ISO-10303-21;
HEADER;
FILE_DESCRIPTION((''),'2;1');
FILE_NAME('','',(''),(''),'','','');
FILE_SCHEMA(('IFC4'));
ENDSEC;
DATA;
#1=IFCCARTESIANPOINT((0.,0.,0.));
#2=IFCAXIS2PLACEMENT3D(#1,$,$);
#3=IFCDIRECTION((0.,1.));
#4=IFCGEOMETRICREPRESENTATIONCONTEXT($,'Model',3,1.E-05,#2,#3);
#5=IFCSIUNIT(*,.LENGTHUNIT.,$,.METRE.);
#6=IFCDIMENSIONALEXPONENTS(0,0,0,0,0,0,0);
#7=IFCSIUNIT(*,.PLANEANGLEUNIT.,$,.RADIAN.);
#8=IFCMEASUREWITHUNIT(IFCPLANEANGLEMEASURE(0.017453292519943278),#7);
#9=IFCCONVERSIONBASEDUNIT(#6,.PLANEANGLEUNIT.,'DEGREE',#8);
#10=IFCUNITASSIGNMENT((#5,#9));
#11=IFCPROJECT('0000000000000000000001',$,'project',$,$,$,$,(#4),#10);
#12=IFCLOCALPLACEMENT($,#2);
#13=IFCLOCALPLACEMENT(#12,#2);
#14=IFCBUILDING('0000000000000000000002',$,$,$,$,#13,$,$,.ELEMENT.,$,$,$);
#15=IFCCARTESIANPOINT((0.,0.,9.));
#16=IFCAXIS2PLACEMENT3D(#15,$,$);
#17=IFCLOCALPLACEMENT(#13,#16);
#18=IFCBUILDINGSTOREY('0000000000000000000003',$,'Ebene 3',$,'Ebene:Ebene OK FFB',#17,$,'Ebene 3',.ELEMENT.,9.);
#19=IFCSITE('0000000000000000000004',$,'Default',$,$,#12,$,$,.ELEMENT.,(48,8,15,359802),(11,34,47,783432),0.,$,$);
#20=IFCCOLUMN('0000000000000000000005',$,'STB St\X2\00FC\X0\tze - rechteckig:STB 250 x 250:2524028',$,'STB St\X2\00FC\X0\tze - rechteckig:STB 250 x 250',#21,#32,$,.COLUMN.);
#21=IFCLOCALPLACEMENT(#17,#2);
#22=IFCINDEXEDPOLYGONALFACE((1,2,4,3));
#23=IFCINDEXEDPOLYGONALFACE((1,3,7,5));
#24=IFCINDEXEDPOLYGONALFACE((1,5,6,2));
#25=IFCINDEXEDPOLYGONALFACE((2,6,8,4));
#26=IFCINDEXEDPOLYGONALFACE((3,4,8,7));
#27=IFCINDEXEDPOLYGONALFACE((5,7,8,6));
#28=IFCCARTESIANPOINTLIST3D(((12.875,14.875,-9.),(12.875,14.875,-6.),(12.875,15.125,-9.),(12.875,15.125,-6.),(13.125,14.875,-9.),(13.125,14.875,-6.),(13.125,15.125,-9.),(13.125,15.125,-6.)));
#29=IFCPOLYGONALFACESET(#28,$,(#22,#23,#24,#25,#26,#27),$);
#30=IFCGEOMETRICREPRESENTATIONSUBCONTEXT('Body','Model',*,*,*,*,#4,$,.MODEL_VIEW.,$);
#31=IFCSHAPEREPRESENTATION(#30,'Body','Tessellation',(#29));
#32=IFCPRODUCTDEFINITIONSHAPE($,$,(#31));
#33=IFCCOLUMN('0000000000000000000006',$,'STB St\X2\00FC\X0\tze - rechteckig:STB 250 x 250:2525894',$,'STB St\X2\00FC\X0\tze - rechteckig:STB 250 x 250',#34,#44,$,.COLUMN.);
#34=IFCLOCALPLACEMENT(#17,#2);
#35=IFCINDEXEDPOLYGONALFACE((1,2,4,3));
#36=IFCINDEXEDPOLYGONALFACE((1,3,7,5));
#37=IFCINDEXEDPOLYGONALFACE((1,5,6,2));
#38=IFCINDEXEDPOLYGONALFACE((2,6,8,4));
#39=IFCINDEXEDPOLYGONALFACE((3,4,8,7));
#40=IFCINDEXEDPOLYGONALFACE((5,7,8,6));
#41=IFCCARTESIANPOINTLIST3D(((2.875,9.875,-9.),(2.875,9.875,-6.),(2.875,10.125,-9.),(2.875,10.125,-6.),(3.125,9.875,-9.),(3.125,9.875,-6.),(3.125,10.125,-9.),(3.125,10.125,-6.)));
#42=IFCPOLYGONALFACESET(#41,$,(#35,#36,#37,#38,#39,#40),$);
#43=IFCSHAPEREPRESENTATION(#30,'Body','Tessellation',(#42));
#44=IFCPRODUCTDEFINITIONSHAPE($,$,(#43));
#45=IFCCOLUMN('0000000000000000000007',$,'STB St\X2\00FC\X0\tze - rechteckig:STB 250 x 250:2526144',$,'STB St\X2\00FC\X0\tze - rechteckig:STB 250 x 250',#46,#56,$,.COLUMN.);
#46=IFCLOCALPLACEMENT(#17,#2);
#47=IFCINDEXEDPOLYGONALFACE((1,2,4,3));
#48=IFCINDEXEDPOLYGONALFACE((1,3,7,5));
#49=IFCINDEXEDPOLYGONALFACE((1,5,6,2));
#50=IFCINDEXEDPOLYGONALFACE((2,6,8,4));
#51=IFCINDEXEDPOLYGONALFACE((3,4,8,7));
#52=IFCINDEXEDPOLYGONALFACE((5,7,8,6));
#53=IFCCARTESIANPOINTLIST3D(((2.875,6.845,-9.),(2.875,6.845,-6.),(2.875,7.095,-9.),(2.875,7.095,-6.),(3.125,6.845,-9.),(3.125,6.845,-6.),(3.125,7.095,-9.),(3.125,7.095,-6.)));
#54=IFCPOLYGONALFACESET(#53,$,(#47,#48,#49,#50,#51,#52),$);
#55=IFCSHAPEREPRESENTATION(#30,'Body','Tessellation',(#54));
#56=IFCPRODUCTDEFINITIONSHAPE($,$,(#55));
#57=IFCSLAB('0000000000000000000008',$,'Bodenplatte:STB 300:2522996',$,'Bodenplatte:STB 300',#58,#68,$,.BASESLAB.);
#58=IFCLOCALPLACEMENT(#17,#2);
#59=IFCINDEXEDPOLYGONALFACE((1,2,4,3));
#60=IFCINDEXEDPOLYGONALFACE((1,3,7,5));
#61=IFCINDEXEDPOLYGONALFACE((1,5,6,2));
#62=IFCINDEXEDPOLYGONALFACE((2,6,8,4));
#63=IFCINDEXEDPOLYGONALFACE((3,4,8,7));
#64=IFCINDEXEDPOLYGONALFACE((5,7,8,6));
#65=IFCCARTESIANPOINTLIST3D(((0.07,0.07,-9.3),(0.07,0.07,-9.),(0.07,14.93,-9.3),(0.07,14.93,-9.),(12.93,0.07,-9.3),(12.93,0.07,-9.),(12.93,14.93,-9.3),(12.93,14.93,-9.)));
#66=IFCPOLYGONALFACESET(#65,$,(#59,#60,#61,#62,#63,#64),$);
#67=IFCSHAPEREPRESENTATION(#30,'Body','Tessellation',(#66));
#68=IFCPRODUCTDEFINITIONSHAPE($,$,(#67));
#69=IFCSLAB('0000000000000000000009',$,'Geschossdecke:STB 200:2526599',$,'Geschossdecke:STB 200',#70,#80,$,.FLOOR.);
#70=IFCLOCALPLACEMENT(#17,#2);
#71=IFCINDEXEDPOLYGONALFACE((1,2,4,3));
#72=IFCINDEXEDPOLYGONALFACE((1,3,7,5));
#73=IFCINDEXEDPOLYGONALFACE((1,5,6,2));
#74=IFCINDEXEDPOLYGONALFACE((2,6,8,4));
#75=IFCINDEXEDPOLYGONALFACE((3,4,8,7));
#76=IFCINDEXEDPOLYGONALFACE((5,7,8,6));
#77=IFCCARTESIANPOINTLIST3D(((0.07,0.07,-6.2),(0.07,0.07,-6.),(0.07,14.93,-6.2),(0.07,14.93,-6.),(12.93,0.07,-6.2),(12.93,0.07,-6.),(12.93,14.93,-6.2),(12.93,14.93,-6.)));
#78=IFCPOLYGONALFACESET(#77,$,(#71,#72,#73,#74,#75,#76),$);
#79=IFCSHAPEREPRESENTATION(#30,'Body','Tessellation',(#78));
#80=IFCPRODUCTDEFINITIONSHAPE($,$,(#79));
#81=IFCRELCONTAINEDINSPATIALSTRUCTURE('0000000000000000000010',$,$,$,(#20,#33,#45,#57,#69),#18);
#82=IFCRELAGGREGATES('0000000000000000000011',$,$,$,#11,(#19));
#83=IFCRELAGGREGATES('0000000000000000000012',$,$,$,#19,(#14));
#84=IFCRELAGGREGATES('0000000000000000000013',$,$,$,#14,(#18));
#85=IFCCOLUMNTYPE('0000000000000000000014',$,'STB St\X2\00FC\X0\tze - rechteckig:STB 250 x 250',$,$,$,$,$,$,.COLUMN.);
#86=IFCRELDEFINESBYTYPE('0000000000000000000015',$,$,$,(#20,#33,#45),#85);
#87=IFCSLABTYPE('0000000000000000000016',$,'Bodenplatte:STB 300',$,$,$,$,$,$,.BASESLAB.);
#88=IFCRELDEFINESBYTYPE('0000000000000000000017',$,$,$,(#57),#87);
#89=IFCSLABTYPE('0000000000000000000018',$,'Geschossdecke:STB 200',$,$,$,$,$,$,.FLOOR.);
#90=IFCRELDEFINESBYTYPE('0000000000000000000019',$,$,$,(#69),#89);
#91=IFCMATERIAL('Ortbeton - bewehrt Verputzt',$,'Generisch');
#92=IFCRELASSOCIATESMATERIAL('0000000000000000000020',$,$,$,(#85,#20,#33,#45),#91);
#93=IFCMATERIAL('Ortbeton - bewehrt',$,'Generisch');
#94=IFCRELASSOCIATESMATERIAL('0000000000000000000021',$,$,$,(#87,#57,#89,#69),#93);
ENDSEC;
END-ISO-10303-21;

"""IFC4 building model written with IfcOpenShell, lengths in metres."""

from ifc_helpers import new_model, entity, si_unit, converted_unit, direction, frame, origin, place, context, subcontext, project, spatial, indexed_curve, outline, extrude, source, transform, mapped, material, type_object, type_shapes, element, save


model = new_model("IFC4")

# Units and contexts
model_context = context("Model", 3, precision=1e-05, world=origin(), true_north=direction((0.0, 1.0)))
body_context = subcontext(model_context, "Body", "Model", "MODEL_VIEW")
ifc_project = project(units=[si_unit("LENGTHUNIT", "METRE"), converted_unit("PLANEANGLEUNIT", "DEGREE", entity("IfcPlaneAngleMeasure", 0.017453292519943278), si_unit("PLANEANGLEUNIT", "RADIAN"), dimensions=[0, 0, 0, 0, 0, 0, 0])], contexts=[model_context])

# Site, building, storey
site_placement = place(None, origin())
site = spatial("IfcSite", under=ifc_project, at=site_placement, Name="Default", CompositionType="ELEMENT", RefLatitude=(48, 8, 15, 359802), RefLongitude=(11, 34, 47, 783432), RefElevation=0.0)
building_placement = place(site_placement, origin())
building = spatial("IfcBuilding", under=site, at=building_placement, CompositionType="ELEMENT")
storey_placement = place(building_placement, frame((0.0, 0.0, 9.0)))
storey = spatial("IfcBuildingStorey", under=building, at=storey_placement, Name="Ebene 3", ObjectType="Ebene:Ebene OK FFB", LongName="Ebene 3", CompositionType="ELEMENT", Elevation=9.0)

# Columns
ifc_material_1 = material(Name="Ortbeton - bewehrt Verputzt", Category="Generisch")
column_type = type_object("IfcColumnType", Name="STB Stütze - rechteckig:STB 250 x 250", PredefinedType="COLUMN", material=ifc_material_1)
shared_shape = source(origin(), body_context, "Body", "SweptSolid", [
    extrude(outline(indexed_curve([(-0.125, -0.125), (0.125, -0.125), (0.125, 0.125), (-0.125, 0.125), (-0.125, -0.125)], self_intersect=False)), frame((0.0, 0.0, 0.0), z_axis=(0.0, 0.0, 1.0), x_axis=(-1.0, 0.0, 0.0)), (0.0, 0.0, 1.0), 3.0),
])
type_shapes(column_type, [shared_shape])
for number, where, name in (
    (1, (13.0, 15.0, -9.0), "STB Stütze - rechteckig:STB 250 x 250:2524028"),
    (2, (3.0, 10.0, -9.0), "STB Stütze - rechteckig:STB 250 x 250:2525894"),
    (3, (3.0, 6.97, -9.0), "STB Stütze - rechteckig:STB 250 x 250:2526144"),
):
    element("IfcColumn", number, at=place(storey_placement, frame(where)), inside=storey, type_object=column_type, material=ifc_material_1, Name=name, ObjectType="STB Stütze - rechteckig:STB 250 x 250", PredefinedType="COLUMN", context=body_context, shape_type="MappedRepresentation", body=[
        mapped(shared_shape, transform((0.0, 0.0, 0.0), scale=1.0)),
    ])

# Slabs
ifc_material_2 = material(Name="Ortbeton - bewehrt", Category="Generisch")
slab_type_1 = type_object("IfcSlabType", Name="Bodenplatte:STB 300", PredefinedType="BASESLAB", material=ifc_material_2)
slab_1_placement = place(storey_placement, origin())
element("IfcSlab", 4, at=slab_1_placement, inside=storey, type_object=slab_type_1, material=ifc_material_2, Name="Bodenplatte:STB 300:2522996", ObjectType="Bodenplatte:STB 300", PredefinedType="BASESLAB", context=body_context, shape_type="SweptSolid", body=[
    extrude(outline(indexed_curve([(-7.43, -6.43), (7.43, -6.43), (7.43, 6.43), (-7.43, 6.43), (-7.43, -6.43)], self_intersect=False)), frame((6.5, 7.5, -9.0), z_axis=(0.0, 0.0, -1.0), x_axis=(0.0, 1.0, 0.0)), (0.0, 0.0, 1.0), 0.3),
])
slab_type_2 = type_object("IfcSlabType", Name="Geschossdecke:STB 200", PredefinedType="FLOOR", material=ifc_material_2)
slab_2_placement = place(storey_placement, origin())
element("IfcSlab", 5, at=slab_2_placement, inside=storey, type_object=slab_type_2, material=ifc_material_2, Name="Geschossdecke:STB 200:2526599", ObjectType="Geschossdecke:STB 200", PredefinedType="FLOOR", context=body_context, shape_type="SweptSolid", body=[
    extrude(outline(indexed_curve([(-7.43, -6.43), (7.43, -6.43), (7.43, 6.43), (-7.43, 6.43), (-7.43, -6.43)], self_intersect=False)), frame((6.5, 7.5, -6.0), z_axis=(0.0, 0.0, -1.0), x_axis=(0.0, 1.0, 0.0)), (0.0, 0.0, 1.0), 0.2),
])

save(model, "model.ifc")
